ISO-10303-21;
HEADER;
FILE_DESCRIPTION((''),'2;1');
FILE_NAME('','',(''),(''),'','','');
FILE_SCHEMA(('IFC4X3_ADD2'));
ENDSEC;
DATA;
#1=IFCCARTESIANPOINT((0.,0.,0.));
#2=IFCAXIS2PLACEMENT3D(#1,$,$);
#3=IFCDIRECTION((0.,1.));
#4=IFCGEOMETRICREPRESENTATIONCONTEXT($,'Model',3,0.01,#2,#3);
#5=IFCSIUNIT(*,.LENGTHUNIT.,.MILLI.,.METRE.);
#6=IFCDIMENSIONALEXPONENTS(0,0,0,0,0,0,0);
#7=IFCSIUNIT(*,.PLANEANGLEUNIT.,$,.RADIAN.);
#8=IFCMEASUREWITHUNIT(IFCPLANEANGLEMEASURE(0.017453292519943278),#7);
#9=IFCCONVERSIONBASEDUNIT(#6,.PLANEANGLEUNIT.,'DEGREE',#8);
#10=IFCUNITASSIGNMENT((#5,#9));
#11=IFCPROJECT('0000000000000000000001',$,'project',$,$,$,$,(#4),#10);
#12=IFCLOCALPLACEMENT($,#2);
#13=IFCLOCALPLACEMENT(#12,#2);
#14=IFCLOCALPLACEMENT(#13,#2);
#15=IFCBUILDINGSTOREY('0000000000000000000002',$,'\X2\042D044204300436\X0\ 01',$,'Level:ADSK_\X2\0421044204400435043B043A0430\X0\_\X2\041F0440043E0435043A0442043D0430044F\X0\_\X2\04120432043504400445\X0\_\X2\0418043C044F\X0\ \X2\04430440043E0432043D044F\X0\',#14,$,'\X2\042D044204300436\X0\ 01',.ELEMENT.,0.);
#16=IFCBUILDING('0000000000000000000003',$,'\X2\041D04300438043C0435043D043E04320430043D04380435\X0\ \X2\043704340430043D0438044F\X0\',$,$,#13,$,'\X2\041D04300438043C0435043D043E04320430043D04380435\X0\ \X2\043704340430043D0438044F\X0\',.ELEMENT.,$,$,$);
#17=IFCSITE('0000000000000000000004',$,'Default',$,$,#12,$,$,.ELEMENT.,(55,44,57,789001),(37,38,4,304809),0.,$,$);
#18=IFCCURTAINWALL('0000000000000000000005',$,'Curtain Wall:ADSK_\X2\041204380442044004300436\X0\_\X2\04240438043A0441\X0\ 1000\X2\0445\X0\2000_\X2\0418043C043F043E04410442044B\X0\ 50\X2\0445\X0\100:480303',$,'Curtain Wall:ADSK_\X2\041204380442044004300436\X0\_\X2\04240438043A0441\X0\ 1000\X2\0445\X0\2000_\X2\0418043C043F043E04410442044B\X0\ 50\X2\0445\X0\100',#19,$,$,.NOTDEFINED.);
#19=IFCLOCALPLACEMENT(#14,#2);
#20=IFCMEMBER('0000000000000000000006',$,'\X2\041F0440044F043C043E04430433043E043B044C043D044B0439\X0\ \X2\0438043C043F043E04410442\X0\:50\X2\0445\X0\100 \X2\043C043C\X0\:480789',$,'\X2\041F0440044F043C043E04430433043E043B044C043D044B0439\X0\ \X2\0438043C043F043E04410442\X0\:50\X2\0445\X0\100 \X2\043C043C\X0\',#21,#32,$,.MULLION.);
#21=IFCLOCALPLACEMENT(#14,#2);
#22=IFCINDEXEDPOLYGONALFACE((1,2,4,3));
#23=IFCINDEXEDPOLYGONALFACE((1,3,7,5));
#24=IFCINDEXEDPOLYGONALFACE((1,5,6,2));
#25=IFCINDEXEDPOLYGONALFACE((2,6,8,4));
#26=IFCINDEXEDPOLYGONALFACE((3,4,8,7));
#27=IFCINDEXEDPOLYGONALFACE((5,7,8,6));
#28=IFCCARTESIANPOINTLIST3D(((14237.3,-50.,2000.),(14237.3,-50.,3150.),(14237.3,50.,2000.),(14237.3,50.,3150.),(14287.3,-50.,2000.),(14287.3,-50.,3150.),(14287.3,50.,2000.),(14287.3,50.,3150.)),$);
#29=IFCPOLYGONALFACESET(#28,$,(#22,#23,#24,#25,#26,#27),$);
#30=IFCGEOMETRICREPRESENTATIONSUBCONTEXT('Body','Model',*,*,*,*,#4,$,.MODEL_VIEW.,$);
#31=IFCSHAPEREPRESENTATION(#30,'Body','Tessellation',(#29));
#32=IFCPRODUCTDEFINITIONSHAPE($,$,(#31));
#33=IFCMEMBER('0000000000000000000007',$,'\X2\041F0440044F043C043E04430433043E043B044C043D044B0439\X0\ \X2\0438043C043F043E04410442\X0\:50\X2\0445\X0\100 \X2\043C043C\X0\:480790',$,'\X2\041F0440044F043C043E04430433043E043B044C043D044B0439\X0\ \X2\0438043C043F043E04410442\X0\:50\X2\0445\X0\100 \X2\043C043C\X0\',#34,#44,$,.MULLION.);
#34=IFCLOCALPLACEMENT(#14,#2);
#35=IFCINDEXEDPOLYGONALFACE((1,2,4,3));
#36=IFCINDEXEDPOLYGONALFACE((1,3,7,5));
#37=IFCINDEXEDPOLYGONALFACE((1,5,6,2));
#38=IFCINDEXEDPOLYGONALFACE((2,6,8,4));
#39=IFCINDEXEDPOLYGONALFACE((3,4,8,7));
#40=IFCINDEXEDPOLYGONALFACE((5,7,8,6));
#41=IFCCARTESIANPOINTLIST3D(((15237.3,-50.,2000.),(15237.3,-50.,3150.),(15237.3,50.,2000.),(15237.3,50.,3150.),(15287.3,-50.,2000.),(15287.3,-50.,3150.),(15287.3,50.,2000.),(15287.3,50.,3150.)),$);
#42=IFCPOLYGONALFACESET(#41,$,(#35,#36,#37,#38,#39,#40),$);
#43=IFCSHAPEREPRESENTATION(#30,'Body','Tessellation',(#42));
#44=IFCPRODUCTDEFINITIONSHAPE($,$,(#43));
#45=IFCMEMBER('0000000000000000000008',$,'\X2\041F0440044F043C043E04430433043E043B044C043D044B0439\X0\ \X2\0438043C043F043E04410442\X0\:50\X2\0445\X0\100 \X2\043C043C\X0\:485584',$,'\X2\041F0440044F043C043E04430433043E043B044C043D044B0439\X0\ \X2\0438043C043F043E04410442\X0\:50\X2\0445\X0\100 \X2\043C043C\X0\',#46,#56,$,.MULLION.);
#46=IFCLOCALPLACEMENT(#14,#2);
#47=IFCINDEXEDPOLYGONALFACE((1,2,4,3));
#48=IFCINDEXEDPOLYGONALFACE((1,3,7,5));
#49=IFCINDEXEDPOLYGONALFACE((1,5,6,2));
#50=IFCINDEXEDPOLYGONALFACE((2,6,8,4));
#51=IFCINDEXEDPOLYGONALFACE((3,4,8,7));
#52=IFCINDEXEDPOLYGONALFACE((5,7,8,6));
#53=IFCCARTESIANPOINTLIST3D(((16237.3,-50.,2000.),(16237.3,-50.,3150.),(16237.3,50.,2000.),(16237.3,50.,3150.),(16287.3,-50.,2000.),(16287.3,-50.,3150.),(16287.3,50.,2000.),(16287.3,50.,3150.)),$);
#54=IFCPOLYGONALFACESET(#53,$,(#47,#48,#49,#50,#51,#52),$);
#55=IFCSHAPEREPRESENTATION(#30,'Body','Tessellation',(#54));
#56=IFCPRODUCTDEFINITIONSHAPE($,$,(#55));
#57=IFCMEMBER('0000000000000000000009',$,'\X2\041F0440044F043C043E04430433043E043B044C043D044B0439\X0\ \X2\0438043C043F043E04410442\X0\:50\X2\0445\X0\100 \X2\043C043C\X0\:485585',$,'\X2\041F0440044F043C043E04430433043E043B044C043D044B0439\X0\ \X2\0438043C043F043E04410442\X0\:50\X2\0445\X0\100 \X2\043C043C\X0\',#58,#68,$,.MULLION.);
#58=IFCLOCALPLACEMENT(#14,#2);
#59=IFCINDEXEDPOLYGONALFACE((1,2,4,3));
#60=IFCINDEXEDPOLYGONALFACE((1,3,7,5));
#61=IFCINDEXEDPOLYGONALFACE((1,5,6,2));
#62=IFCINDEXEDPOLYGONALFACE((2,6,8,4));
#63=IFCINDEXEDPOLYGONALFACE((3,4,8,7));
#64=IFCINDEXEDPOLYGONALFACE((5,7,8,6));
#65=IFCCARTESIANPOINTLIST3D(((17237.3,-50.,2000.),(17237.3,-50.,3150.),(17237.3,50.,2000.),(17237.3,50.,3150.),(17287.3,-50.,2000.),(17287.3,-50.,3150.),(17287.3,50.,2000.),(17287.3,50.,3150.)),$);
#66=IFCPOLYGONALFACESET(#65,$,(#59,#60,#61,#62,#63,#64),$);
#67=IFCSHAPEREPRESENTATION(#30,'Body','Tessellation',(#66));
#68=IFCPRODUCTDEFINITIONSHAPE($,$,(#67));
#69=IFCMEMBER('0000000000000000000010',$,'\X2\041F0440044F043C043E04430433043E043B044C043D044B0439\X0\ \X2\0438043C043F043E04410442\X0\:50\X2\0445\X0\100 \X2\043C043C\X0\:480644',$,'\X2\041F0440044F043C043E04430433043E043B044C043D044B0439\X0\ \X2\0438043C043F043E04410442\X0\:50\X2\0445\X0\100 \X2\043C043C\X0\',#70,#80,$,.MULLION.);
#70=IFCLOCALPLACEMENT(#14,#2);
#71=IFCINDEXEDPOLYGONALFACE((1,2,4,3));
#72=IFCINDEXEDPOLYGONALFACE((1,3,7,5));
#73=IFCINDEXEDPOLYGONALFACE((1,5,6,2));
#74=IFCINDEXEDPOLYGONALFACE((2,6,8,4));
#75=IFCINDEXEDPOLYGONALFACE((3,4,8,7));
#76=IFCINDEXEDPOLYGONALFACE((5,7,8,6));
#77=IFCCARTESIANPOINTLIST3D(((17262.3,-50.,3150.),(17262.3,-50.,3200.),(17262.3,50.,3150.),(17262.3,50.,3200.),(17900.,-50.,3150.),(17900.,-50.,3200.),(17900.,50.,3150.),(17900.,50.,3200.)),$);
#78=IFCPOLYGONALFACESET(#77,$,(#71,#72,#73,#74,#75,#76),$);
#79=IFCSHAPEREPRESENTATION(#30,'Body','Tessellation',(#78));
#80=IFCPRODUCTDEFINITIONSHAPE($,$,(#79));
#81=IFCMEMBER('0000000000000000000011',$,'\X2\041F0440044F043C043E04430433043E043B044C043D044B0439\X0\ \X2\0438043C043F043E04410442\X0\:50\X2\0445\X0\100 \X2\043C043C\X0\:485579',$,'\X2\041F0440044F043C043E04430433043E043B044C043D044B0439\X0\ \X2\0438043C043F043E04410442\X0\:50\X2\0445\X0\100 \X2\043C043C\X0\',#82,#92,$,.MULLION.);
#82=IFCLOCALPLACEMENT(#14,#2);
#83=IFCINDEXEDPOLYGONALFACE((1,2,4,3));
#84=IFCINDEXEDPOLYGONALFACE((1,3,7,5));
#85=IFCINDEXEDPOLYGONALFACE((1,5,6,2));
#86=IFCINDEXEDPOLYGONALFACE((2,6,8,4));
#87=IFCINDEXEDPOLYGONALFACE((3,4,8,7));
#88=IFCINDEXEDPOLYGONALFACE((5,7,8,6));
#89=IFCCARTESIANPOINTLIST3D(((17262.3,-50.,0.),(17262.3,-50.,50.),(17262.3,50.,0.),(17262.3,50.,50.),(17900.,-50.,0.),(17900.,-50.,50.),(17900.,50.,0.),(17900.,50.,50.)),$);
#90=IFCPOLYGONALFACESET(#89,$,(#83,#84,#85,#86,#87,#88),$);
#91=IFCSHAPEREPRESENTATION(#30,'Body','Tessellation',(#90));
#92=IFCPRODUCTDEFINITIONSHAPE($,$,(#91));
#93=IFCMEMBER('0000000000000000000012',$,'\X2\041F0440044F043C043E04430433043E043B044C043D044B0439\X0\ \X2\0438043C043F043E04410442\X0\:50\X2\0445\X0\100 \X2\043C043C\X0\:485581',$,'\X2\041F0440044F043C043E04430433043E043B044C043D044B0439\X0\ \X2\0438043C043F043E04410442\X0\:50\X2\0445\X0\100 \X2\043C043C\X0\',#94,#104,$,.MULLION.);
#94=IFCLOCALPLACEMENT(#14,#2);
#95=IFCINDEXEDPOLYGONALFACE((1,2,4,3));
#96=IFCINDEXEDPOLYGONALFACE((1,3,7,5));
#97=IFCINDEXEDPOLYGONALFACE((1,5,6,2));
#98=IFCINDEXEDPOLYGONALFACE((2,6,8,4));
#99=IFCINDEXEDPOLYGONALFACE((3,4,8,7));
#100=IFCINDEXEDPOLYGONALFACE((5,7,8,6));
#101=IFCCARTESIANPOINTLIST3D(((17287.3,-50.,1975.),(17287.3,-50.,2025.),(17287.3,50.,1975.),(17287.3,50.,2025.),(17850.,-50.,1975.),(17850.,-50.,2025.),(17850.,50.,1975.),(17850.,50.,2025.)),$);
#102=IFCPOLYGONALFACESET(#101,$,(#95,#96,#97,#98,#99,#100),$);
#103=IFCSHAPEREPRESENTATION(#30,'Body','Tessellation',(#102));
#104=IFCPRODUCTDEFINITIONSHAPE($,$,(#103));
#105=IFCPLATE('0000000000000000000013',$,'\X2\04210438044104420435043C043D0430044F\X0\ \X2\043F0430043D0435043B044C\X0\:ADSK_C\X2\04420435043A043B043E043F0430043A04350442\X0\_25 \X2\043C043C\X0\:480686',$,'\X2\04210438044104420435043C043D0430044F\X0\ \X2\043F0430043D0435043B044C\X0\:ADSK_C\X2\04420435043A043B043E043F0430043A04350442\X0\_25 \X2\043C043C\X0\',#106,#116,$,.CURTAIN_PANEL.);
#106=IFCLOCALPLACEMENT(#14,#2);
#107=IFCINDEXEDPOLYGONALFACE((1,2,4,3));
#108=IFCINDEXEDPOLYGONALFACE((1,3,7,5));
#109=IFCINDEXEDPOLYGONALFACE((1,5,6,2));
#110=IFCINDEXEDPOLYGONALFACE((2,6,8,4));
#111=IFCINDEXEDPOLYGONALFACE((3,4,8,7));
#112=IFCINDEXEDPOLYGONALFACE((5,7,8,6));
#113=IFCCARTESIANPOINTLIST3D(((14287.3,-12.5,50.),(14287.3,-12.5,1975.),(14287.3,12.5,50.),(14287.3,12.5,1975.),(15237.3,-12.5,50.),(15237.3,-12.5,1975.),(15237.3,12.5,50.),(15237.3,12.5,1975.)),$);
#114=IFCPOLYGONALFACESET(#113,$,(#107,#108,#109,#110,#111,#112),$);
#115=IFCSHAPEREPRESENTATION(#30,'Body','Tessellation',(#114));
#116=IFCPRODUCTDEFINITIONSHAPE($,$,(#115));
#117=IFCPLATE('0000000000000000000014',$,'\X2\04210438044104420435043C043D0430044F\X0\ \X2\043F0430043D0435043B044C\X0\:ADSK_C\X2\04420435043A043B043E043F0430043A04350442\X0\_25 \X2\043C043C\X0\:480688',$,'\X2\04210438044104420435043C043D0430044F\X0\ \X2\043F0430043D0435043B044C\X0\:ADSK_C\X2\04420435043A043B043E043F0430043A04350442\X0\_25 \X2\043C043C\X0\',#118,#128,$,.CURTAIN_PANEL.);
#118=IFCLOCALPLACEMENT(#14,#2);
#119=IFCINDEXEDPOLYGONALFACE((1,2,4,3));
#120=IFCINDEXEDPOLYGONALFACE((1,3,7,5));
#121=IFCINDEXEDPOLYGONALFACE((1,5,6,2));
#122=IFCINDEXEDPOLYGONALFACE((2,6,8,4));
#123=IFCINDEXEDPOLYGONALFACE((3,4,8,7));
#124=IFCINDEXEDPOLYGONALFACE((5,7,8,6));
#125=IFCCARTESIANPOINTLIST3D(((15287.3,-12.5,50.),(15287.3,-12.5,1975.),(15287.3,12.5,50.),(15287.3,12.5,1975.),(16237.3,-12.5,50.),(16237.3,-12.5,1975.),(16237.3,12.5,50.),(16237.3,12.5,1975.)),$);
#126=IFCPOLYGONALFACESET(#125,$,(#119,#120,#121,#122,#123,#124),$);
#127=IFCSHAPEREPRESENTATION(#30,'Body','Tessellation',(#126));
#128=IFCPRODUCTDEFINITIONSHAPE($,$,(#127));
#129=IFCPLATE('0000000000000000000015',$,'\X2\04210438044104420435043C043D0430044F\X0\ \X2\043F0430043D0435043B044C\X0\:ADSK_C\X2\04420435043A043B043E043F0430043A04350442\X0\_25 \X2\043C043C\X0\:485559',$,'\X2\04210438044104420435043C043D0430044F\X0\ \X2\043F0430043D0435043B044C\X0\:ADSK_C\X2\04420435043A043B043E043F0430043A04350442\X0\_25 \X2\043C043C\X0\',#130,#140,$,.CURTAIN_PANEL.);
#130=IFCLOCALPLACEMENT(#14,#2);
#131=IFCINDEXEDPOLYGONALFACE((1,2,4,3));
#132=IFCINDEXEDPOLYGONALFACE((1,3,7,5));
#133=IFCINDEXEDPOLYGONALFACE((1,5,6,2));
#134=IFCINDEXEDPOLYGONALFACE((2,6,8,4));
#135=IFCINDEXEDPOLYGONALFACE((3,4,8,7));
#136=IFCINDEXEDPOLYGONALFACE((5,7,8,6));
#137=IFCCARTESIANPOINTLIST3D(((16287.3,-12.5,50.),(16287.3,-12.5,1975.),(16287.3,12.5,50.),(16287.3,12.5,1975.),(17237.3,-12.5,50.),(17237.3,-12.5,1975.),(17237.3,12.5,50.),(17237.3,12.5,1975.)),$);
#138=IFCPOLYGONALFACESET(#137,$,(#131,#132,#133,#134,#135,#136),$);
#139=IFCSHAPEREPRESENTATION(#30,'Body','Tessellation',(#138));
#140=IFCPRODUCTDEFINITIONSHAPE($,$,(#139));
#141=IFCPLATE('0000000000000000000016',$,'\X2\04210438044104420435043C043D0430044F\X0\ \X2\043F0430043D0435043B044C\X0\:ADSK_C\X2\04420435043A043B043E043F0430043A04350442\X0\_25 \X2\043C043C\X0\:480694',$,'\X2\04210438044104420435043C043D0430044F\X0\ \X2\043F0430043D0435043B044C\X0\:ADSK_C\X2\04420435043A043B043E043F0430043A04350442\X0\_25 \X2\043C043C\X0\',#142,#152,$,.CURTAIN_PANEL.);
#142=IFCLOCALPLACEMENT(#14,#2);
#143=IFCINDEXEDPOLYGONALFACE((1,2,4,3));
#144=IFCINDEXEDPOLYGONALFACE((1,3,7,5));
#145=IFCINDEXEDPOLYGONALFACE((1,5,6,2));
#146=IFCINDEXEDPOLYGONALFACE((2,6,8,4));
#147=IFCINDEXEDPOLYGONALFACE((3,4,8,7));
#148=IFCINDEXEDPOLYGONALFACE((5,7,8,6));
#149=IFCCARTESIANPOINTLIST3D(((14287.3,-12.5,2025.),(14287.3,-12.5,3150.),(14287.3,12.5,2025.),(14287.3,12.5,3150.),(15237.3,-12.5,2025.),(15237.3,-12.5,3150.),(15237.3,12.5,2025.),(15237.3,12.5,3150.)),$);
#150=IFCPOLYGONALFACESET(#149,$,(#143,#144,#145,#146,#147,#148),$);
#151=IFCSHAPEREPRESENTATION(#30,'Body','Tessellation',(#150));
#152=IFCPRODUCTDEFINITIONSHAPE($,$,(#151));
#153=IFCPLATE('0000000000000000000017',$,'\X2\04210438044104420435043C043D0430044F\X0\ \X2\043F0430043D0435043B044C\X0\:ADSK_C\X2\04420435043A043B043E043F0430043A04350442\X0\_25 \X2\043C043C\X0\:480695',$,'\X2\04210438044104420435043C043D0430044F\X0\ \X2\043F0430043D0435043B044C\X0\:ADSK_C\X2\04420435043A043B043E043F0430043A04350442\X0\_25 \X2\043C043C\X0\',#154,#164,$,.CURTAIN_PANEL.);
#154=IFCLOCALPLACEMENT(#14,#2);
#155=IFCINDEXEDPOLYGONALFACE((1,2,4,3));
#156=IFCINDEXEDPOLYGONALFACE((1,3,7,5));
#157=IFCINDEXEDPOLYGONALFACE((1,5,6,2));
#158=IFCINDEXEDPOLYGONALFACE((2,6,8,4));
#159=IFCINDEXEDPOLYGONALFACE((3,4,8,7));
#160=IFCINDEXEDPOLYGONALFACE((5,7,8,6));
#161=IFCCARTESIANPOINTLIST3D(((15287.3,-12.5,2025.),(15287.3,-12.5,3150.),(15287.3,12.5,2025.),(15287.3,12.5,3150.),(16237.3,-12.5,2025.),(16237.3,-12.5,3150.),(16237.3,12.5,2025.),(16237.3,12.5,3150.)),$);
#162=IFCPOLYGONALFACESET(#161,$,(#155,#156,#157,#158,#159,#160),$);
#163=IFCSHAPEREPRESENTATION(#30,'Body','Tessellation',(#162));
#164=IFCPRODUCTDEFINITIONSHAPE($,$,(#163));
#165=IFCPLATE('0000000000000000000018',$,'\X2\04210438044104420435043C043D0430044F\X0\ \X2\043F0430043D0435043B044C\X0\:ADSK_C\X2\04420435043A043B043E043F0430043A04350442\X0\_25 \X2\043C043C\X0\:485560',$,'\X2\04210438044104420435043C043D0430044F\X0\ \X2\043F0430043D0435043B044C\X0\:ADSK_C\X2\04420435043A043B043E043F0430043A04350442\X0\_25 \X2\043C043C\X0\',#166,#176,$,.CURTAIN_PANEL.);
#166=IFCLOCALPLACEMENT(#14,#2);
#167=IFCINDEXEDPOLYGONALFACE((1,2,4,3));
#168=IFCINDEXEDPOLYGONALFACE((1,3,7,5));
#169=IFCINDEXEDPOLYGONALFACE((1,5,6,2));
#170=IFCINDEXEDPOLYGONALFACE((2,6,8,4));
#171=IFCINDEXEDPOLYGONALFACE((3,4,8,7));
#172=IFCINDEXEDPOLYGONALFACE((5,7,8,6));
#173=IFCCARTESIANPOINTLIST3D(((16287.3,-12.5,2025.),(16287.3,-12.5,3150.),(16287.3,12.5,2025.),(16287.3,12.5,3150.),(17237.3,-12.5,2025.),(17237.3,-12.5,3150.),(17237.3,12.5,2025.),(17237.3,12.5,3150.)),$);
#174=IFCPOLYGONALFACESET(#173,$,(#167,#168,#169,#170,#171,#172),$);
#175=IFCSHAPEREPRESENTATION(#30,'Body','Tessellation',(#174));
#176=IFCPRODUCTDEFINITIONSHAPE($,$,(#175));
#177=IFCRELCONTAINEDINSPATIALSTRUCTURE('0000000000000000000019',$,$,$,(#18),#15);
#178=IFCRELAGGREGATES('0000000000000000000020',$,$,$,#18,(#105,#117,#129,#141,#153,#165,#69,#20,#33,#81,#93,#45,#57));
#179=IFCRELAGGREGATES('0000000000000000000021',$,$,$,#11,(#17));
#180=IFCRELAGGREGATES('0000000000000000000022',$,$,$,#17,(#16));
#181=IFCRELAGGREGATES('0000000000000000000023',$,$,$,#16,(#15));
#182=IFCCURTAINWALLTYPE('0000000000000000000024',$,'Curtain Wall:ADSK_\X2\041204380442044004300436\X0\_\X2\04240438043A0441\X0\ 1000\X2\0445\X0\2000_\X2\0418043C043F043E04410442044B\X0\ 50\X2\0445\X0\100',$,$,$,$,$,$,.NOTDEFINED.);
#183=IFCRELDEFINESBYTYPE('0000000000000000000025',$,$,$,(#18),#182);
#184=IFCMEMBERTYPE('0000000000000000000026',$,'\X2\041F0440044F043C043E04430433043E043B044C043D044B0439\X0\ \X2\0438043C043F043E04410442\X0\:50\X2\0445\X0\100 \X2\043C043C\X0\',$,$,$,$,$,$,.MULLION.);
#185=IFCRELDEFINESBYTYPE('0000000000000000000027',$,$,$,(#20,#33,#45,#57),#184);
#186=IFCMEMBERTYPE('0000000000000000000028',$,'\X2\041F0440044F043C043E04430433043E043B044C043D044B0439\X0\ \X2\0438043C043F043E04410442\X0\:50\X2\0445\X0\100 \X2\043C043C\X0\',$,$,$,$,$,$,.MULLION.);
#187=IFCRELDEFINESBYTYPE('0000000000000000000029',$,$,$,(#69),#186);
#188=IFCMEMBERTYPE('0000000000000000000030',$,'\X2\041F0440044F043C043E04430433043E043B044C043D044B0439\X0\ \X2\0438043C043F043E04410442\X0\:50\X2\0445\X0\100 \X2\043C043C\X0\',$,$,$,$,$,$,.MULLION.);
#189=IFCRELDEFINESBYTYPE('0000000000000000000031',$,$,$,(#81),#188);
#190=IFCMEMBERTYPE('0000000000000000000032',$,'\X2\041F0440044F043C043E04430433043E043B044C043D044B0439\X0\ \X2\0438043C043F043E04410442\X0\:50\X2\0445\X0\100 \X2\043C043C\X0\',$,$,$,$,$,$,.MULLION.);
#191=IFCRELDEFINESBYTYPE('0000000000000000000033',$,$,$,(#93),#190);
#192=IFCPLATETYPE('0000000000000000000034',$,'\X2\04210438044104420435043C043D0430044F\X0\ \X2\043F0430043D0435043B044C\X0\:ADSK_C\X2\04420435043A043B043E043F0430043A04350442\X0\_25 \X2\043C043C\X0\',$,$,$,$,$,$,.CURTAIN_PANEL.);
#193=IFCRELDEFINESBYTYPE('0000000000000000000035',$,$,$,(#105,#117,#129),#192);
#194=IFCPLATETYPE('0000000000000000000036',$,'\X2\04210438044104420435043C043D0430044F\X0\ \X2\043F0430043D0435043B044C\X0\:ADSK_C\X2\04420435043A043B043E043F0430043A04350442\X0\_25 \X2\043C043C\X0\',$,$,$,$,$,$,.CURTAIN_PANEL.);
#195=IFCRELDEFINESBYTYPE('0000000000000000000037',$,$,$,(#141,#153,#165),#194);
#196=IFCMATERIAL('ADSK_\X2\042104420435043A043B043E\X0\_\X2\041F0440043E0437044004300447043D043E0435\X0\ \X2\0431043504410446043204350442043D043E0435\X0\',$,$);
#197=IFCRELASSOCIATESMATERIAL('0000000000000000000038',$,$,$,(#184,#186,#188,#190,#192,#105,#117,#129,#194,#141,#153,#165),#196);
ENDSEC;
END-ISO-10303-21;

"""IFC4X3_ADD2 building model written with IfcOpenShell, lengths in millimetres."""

from ifc_helpers import new_model, entity, si_unit, converted_unit, direction, frame, frame_2d, origin, origin_2d_with_axis, place, context, subcontext, project, spatial, rectangle, extrude, source, transform, mapped, material, material_profile, profile_set, type_object, type_shapes, element, aggregate, save


model = new_model("IFC4X3_ADD2")

# Units and contexts
model_context = context("Model", 3, precision=0.01, world=origin(), true_north=direction((0.0, 1.0)))
body_context = subcontext(model_context, "Body", "Model", "MODEL_VIEW")
ifc_project = project(units=[si_unit("LENGTHUNIT", "METRE", prefix="MILLI"), converted_unit("PLANEANGLEUNIT", "DEGREE", entity("IfcPlaneAngleMeasure", 0.017453292519943278), si_unit("PLANEANGLEUNIT", "RADIAN"), dimensions=[0, 0, 0, 0, 0, 0, 0])], contexts=[model_context])

# Site, building, storey
site_placement = place(None, origin())
site = spatial("IfcSite", under=ifc_project, at=site_placement, Name="Default", CompositionType="ELEMENT", RefLatitude=(55, 44, 57, 789001), RefLongitude=(37, 38, 4, 304809), RefElevation=0.0)
building_placement = place(site_placement, origin())
building = spatial("IfcBuilding", under=site, at=building_placement, Name="Наименование здания", LongName="Наименование здания", CompositionType="ELEMENT")
storey_placement = place(building_placement, origin())
storey = spatial("IfcBuildingStorey", under=building, at=storey_placement, Name="Этаж 01", ObjectType="Level:ADSK_Стрелка_Проектная_Вверх_Имя уровня", LongName="Этаж 01", CompositionType="ELEMENT", Elevation=0.0)

# Curtain wall, members, plates
curtain_wall_type = type_object("IfcCurtainWallType", Name="Curtain Wall:ADSK_Витраж_Фикс 1000х2000_Импосты 50х100", PredefinedType="NOTDEFINED")
curtain_wall_placement = place(storey_placement, origin())
curtain_wall = element("IfcCurtainWall", 1, at=curtain_wall_placement, inside=storey, type_object=curtain_wall_type, Name="Curtain Wall:ADSK_Витраж_Фикс 1000х2000_Импосты 50х100:480303", ObjectType="Curtain Wall:ADSK_Витраж_Фикс 1000х2000_Импосты 50х100", PredefinedType="NOTDEFINED")
ifc_material_1 = material(Name="ADSK_Стекло_Прозрачное бесцветное")
ifc_material_profile = material_profile(ifc_material_1, rectangle(XDim=50.0, YDim=100.0, at=frame_2d((0.0, 0.0), x_axis=(1.0, 0.0))), Name="50х100 мм")
ifc_profile_set = profile_set([ifc_material_profile], Name="50х100 мм")
member_type_1 = type_object("IfcMemberType", Name="Прямоугольный импост:50х100 мм", PredefinedType="MULLION", material=ifc_profile_set)
shared_shape_1 = source(origin(), body_context, "Body", "SweptSolid", [
    extrude(rectangle(XDim=50.0, YDim=100.0, at=frame_2d((0.0, 0.0), x_axis=(1.0, 0.0))), frame((0.0, 0.0, -1150.0), z_axis=(0.0, 0.0, 1.0), x_axis=(-1.0, 0.0, 0.0)), (0.0, 0.0, 1.0), 1150.0),
])
type_shapes(member_type_1, [shared_shape_1])
member_1_placement = place(curtain_wall_placement, frame((14262.3, 0.0, 2000.0), z_axis=(0.0, 0.0, -1.0), x_axis=(1.0, 0.0, 0.0)))
member_1 = element("IfcMember", 2, at=member_1_placement, type_object=member_type_1, Name="Прямоугольный импост:50х100 мм:480789", ObjectType="Прямоугольный импост:50х100 мм", PredefinedType="MULLION", context=body_context, shape_type="MappedRepresentation", body=[
    mapped(shared_shape_1, transform((0.0, 0.0, 0.0), scale=1.0)),
])
member_2_placement = place(curtain_wall_placement, frame((15262.3, 0.0, 2000.0), z_axis=(0.0, 0.0, -1.0), x_axis=(1.0, 0.0, 0.0)))
member_2 = element("IfcMember", 3, at=member_2_placement, type_object=member_type_1, Name="Прямоугольный импост:50х100 мм:480790", ObjectType="Прямоугольный импост:50х100 мм", PredefinedType="MULLION", context=body_context, shape_type="MappedRepresentation", body=[
    mapped(shared_shape_1, transform((0.0, 0.0, 0.0), scale=1.0)),
])
member_3_placement = place(curtain_wall_placement, frame((16262.3, 0.0, 2000.0), z_axis=(0.0, 0.0, -1.0), x_axis=(1.0, 0.0, 0.0)))
member_3 = element("IfcMember", 4, at=member_3_placement, type_object=member_type_1, Name="Прямоугольный импост:50х100 мм:485584", ObjectType="Прямоугольный импост:50х100 мм", PredefinedType="MULLION", context=body_context, shape_type="MappedRepresentation", body=[
    mapped(shared_shape_1, transform((0.0, 0.0, 0.0), scale=1.0)),
])
member_4_placement = place(curtain_wall_placement, frame((17262.3, 0.0, 2000.0), z_axis=(0.0, 0.0, -1.0), x_axis=(1.0, 0.0, 0.0)))
member_4 = element("IfcMember", 5, at=member_4_placement, type_object=member_type_1, Name="Прямоугольный импост:50х100 мм:485585", ObjectType="Прямоугольный импост:50х100 мм", PredefinedType="MULLION", context=body_context, shape_type="MappedRepresentation", body=[
    mapped(shared_shape_1, transform((0.0, 0.0, 0.0), scale=1.0)),
])
member_type_2 = type_object("IfcMemberType", Name="Прямоугольный импост:50х100 мм", PredefinedType="MULLION", material=ifc_profile_set)
shared_shape_2 = source(origin(), body_context, "Body", "SweptSolid", [
    extrude(rectangle(XDim=50.0, YDim=100.0, at=frame_2d((0.0, 0.0), x_axis=(1.0, 0.0))), frame((-25.0, 0.0, -637.7), z_axis=(0.0, 0.0, 1.0), x_axis=(-1.0, 0.0, 0.0)), (0.0, 0.0, 1.0), 637.7),
])
type_shapes(member_type_2, [shared_shape_2])
member_5_placement = place(curtain_wall_placement, frame((17900.0, 0.0, 3200.0), z_axis=(1.0, 0.0, 0.0), x_axis=(0.0, 0.0, 1.0)))
member_5 = element("IfcMember", 6, at=member_5_placement, type_object=member_type_2, Name="Прямоугольный импост:50х100 мм:480644", ObjectType="Прямоугольный импост:50х100 мм", PredefinedType="MULLION", context=body_context, shape_type="MappedRepresentation", body=[
    mapped(shared_shape_2, transform((0.0, 0.0, 0.0), scale=1.0)),
])
member_type_3 = type_object("IfcMemberType", Name="Прямоугольный импост:50х100 мм", PredefinedType="MULLION", material=ifc_profile_set)
shared_shape_3 = source(origin(), body_context, "Body", "SweptSolid", [
    extrude(rectangle(XDim=50.0, YDim=100.0, at=frame_2d((0.0, 0.0), x_axis=(1.0, 0.0))), frame((-25.0, 0.0, -637.7), z_axis=(0.0, 0.0, 1.0), x_axis=(-1.0, 0.0, 0.0)), (0.0, 0.0, 1.0), 637.7),
])
type_shapes(member_type_3, [shared_shape_3])
member_6_placement = place(curtain_wall_placement, frame((17262.3, 0.0, 0.0), z_axis=(-1.0, 0.0, 0.0), x_axis=(0.0, 0.0, -1.0)))
member_6 = element("IfcMember", 7, at=member_6_placement, type_object=member_type_3, Name="Прямоугольный импост:50х100 мм:485579", ObjectType="Прямоугольный импост:50х100 мм", PredefinedType="MULLION", context=body_context, shape_type="MappedRepresentation", body=[
    mapped(shared_shape_3, transform((0.0, 0.0, 0.0), scale=1.0)),
])
member_type_4 = type_object("IfcMemberType", Name="Прямоугольный импост:50х100 мм", PredefinedType="MULLION", material=ifc_profile_set)
shared_shape_4 = source(origin(), body_context, "Body", "SweptSolid", [
    extrude(rectangle(XDim=50.0, YDim=100.0, at=frame_2d((0.0, 0.0), x_axis=(1.0, 0.0))), frame((0.0, 0.0, -562.7), z_axis=(0.0, 0.0, 1.0), x_axis=(-1.0, 0.0, 0.0)), (0.0, 0.0, 1.0), 562.7),
])
type_shapes(member_type_4, [shared_shape_4])
member_7_placement = place(curtain_wall_placement, frame((17850.0, 0.0, 2000.0), z_axis=(1.0, 0.0, 0.0), x_axis=(0.0, 0.0, 1.0)))
member_7 = element("IfcMember", 8, at=member_7_placement, type_object=member_type_4, Name="Прямоугольный импост:50х100 мм:485581", ObjectType="Прямоугольный импост:50х100 мм", PredefinedType="MULLION", context=body_context, shape_type="MappedRepresentation", body=[
    mapped(shared_shape_4, transform((0.0, 0.0, 0.0), scale=1.0)),
])
plate_type_1 = type_object("IfcPlateType", Name="Системная панель:ADSK_Cтеклопакет_25 мм", PredefinedType="CURTAIN_PANEL", material=ifc_material_1)
shared_shape_5 = source(origin(), body_context, "Body", "SweptSolid", [
    extrude(rectangle(XDim=25.0, YDim=950.0, at=origin_2d_with_axis()), frame((0.0, 0.0, 0.0), z_axis=(0.0, 0.0, 1.0), x_axis=(0.0, 1.0, 0.0)), (0.0, 0.0, 1.0), 1925.0),
])
type_shapes(plate_type_1, [shared_shape_5])
plate_1_placement = place(curtain_wall_placement, frame((14762.3, 0.0, 50.0)))
plate_1 = element("IfcPlate", 9, at=plate_1_placement, type_object=plate_type_1, material=ifc_material_1, Name="Системная панель:ADSK_Cтеклопакет_25 мм:480686", ObjectType="Системная панель:ADSK_Cтеклопакет_25 мм", PredefinedType="CURTAIN_PANEL", context=body_context, shape_type="MappedRepresentation", body=[
    mapped(shared_shape_5, transform((0.0, 0.0, 0.0), scale=1.0)),
])
plate_2_placement = place(curtain_wall_placement, frame((15762.3, 0.0, 50.0)))
plate_2 = element("IfcPlate", 10, at=plate_2_placement, type_object=plate_type_1, material=ifc_material_1, Name="Системная панель:ADSK_Cтеклопакет_25 мм:480688", ObjectType="Системная панель:ADSK_Cтеклопакет_25 мм", PredefinedType="CURTAIN_PANEL", context=body_context, shape_type="MappedRepresentation", body=[
    mapped(shared_shape_5, transform((0.0, 0.0, 0.0), scale=1.0)),
])
plate_3_placement = place(curtain_wall_placement, frame((16762.3, 0.0, 50.0)))
plate_3 = element("IfcPlate", 11, at=plate_3_placement, type_object=plate_type_1, material=ifc_material_1, Name="Системная панель:ADSK_Cтеклопакет_25 мм:485559", ObjectType="Системная панель:ADSK_Cтеклопакет_25 мм", PredefinedType="CURTAIN_PANEL", context=body_context, shape_type="MappedRepresentation", body=[
    mapped(shared_shape_5, transform((0.0, 0.0, 0.0), scale=1.0)),
])
plate_type_2 = type_object("IfcPlateType", Name="Системная панель:ADSK_Cтеклопакет_25 мм", PredefinedType="CURTAIN_PANEL", material=ifc_material_1)
shared_shape_6 = source(origin(), body_context, "Body", "SweptSolid", [
    extrude(rectangle(XDim=25.0, YDim=950.0, at=origin_2d_with_axis()), frame((0.0, 0.0, 0.0), z_axis=(0.0, 0.0, 1.0), x_axis=(0.0, 1.0, 0.0)), (0.0, 0.0, 1.0), 1125.0),
])
type_shapes(plate_type_2, [shared_shape_6])
plate_4_placement = place(curtain_wall_placement, frame((14762.3, 0.0, 2025.0)))
plate_4 = element("IfcPlate", 12, at=plate_4_placement, type_object=plate_type_2, material=ifc_material_1, Name="Системная панель:ADSK_Cтеклопакет_25 мм:480694", ObjectType="Системная панель:ADSK_Cтеклопакет_25 мм", PredefinedType="CURTAIN_PANEL", context=body_context, shape_type="MappedRepresentation", body=[
    mapped(shared_shape_6, transform((0.0, 0.0, 0.0), scale=1.0)),
])
plate_5_placement = place(curtain_wall_placement, frame((15762.3, 0.0, 2025.0)))
plate_5 = element("IfcPlate", 13, at=plate_5_placement, type_object=plate_type_2, material=ifc_material_1, Name="Системная панель:ADSK_Cтеклопакет_25 мм:480695", ObjectType="Системная панель:ADSK_Cтеклопакет_25 мм", PredefinedType="CURTAIN_PANEL", context=body_context, shape_type="MappedRepresentation", body=[
    mapped(shared_shape_6, transform((0.0, 0.0, 0.0), scale=1.0)),
])
plate_6_placement = place(curtain_wall_placement, frame((16762.3, 0.0, 2025.0)))
plate_6 = element("IfcPlate", 14, at=plate_6_placement, type_object=plate_type_2, material=ifc_material_1, Name="Системная панель:ADSK_Cтеклопакет_25 мм:485560", ObjectType="Системная панель:ADSK_Cтеклопакет_25 мм", PredefinedType="CURTAIN_PANEL", context=body_context, shape_type="MappedRepresentation", body=[
    mapped(shared_shape_6, transform((0.0, 0.0, 0.0), scale=1.0)),
])
aggregate(curtain_wall, [plate_1, plate_2, plate_3, plate_4, plate_5, plate_6, member_5, member_1, member_2, member_6, member_7, member_3, member_4])

save(model, "model.ifc")
